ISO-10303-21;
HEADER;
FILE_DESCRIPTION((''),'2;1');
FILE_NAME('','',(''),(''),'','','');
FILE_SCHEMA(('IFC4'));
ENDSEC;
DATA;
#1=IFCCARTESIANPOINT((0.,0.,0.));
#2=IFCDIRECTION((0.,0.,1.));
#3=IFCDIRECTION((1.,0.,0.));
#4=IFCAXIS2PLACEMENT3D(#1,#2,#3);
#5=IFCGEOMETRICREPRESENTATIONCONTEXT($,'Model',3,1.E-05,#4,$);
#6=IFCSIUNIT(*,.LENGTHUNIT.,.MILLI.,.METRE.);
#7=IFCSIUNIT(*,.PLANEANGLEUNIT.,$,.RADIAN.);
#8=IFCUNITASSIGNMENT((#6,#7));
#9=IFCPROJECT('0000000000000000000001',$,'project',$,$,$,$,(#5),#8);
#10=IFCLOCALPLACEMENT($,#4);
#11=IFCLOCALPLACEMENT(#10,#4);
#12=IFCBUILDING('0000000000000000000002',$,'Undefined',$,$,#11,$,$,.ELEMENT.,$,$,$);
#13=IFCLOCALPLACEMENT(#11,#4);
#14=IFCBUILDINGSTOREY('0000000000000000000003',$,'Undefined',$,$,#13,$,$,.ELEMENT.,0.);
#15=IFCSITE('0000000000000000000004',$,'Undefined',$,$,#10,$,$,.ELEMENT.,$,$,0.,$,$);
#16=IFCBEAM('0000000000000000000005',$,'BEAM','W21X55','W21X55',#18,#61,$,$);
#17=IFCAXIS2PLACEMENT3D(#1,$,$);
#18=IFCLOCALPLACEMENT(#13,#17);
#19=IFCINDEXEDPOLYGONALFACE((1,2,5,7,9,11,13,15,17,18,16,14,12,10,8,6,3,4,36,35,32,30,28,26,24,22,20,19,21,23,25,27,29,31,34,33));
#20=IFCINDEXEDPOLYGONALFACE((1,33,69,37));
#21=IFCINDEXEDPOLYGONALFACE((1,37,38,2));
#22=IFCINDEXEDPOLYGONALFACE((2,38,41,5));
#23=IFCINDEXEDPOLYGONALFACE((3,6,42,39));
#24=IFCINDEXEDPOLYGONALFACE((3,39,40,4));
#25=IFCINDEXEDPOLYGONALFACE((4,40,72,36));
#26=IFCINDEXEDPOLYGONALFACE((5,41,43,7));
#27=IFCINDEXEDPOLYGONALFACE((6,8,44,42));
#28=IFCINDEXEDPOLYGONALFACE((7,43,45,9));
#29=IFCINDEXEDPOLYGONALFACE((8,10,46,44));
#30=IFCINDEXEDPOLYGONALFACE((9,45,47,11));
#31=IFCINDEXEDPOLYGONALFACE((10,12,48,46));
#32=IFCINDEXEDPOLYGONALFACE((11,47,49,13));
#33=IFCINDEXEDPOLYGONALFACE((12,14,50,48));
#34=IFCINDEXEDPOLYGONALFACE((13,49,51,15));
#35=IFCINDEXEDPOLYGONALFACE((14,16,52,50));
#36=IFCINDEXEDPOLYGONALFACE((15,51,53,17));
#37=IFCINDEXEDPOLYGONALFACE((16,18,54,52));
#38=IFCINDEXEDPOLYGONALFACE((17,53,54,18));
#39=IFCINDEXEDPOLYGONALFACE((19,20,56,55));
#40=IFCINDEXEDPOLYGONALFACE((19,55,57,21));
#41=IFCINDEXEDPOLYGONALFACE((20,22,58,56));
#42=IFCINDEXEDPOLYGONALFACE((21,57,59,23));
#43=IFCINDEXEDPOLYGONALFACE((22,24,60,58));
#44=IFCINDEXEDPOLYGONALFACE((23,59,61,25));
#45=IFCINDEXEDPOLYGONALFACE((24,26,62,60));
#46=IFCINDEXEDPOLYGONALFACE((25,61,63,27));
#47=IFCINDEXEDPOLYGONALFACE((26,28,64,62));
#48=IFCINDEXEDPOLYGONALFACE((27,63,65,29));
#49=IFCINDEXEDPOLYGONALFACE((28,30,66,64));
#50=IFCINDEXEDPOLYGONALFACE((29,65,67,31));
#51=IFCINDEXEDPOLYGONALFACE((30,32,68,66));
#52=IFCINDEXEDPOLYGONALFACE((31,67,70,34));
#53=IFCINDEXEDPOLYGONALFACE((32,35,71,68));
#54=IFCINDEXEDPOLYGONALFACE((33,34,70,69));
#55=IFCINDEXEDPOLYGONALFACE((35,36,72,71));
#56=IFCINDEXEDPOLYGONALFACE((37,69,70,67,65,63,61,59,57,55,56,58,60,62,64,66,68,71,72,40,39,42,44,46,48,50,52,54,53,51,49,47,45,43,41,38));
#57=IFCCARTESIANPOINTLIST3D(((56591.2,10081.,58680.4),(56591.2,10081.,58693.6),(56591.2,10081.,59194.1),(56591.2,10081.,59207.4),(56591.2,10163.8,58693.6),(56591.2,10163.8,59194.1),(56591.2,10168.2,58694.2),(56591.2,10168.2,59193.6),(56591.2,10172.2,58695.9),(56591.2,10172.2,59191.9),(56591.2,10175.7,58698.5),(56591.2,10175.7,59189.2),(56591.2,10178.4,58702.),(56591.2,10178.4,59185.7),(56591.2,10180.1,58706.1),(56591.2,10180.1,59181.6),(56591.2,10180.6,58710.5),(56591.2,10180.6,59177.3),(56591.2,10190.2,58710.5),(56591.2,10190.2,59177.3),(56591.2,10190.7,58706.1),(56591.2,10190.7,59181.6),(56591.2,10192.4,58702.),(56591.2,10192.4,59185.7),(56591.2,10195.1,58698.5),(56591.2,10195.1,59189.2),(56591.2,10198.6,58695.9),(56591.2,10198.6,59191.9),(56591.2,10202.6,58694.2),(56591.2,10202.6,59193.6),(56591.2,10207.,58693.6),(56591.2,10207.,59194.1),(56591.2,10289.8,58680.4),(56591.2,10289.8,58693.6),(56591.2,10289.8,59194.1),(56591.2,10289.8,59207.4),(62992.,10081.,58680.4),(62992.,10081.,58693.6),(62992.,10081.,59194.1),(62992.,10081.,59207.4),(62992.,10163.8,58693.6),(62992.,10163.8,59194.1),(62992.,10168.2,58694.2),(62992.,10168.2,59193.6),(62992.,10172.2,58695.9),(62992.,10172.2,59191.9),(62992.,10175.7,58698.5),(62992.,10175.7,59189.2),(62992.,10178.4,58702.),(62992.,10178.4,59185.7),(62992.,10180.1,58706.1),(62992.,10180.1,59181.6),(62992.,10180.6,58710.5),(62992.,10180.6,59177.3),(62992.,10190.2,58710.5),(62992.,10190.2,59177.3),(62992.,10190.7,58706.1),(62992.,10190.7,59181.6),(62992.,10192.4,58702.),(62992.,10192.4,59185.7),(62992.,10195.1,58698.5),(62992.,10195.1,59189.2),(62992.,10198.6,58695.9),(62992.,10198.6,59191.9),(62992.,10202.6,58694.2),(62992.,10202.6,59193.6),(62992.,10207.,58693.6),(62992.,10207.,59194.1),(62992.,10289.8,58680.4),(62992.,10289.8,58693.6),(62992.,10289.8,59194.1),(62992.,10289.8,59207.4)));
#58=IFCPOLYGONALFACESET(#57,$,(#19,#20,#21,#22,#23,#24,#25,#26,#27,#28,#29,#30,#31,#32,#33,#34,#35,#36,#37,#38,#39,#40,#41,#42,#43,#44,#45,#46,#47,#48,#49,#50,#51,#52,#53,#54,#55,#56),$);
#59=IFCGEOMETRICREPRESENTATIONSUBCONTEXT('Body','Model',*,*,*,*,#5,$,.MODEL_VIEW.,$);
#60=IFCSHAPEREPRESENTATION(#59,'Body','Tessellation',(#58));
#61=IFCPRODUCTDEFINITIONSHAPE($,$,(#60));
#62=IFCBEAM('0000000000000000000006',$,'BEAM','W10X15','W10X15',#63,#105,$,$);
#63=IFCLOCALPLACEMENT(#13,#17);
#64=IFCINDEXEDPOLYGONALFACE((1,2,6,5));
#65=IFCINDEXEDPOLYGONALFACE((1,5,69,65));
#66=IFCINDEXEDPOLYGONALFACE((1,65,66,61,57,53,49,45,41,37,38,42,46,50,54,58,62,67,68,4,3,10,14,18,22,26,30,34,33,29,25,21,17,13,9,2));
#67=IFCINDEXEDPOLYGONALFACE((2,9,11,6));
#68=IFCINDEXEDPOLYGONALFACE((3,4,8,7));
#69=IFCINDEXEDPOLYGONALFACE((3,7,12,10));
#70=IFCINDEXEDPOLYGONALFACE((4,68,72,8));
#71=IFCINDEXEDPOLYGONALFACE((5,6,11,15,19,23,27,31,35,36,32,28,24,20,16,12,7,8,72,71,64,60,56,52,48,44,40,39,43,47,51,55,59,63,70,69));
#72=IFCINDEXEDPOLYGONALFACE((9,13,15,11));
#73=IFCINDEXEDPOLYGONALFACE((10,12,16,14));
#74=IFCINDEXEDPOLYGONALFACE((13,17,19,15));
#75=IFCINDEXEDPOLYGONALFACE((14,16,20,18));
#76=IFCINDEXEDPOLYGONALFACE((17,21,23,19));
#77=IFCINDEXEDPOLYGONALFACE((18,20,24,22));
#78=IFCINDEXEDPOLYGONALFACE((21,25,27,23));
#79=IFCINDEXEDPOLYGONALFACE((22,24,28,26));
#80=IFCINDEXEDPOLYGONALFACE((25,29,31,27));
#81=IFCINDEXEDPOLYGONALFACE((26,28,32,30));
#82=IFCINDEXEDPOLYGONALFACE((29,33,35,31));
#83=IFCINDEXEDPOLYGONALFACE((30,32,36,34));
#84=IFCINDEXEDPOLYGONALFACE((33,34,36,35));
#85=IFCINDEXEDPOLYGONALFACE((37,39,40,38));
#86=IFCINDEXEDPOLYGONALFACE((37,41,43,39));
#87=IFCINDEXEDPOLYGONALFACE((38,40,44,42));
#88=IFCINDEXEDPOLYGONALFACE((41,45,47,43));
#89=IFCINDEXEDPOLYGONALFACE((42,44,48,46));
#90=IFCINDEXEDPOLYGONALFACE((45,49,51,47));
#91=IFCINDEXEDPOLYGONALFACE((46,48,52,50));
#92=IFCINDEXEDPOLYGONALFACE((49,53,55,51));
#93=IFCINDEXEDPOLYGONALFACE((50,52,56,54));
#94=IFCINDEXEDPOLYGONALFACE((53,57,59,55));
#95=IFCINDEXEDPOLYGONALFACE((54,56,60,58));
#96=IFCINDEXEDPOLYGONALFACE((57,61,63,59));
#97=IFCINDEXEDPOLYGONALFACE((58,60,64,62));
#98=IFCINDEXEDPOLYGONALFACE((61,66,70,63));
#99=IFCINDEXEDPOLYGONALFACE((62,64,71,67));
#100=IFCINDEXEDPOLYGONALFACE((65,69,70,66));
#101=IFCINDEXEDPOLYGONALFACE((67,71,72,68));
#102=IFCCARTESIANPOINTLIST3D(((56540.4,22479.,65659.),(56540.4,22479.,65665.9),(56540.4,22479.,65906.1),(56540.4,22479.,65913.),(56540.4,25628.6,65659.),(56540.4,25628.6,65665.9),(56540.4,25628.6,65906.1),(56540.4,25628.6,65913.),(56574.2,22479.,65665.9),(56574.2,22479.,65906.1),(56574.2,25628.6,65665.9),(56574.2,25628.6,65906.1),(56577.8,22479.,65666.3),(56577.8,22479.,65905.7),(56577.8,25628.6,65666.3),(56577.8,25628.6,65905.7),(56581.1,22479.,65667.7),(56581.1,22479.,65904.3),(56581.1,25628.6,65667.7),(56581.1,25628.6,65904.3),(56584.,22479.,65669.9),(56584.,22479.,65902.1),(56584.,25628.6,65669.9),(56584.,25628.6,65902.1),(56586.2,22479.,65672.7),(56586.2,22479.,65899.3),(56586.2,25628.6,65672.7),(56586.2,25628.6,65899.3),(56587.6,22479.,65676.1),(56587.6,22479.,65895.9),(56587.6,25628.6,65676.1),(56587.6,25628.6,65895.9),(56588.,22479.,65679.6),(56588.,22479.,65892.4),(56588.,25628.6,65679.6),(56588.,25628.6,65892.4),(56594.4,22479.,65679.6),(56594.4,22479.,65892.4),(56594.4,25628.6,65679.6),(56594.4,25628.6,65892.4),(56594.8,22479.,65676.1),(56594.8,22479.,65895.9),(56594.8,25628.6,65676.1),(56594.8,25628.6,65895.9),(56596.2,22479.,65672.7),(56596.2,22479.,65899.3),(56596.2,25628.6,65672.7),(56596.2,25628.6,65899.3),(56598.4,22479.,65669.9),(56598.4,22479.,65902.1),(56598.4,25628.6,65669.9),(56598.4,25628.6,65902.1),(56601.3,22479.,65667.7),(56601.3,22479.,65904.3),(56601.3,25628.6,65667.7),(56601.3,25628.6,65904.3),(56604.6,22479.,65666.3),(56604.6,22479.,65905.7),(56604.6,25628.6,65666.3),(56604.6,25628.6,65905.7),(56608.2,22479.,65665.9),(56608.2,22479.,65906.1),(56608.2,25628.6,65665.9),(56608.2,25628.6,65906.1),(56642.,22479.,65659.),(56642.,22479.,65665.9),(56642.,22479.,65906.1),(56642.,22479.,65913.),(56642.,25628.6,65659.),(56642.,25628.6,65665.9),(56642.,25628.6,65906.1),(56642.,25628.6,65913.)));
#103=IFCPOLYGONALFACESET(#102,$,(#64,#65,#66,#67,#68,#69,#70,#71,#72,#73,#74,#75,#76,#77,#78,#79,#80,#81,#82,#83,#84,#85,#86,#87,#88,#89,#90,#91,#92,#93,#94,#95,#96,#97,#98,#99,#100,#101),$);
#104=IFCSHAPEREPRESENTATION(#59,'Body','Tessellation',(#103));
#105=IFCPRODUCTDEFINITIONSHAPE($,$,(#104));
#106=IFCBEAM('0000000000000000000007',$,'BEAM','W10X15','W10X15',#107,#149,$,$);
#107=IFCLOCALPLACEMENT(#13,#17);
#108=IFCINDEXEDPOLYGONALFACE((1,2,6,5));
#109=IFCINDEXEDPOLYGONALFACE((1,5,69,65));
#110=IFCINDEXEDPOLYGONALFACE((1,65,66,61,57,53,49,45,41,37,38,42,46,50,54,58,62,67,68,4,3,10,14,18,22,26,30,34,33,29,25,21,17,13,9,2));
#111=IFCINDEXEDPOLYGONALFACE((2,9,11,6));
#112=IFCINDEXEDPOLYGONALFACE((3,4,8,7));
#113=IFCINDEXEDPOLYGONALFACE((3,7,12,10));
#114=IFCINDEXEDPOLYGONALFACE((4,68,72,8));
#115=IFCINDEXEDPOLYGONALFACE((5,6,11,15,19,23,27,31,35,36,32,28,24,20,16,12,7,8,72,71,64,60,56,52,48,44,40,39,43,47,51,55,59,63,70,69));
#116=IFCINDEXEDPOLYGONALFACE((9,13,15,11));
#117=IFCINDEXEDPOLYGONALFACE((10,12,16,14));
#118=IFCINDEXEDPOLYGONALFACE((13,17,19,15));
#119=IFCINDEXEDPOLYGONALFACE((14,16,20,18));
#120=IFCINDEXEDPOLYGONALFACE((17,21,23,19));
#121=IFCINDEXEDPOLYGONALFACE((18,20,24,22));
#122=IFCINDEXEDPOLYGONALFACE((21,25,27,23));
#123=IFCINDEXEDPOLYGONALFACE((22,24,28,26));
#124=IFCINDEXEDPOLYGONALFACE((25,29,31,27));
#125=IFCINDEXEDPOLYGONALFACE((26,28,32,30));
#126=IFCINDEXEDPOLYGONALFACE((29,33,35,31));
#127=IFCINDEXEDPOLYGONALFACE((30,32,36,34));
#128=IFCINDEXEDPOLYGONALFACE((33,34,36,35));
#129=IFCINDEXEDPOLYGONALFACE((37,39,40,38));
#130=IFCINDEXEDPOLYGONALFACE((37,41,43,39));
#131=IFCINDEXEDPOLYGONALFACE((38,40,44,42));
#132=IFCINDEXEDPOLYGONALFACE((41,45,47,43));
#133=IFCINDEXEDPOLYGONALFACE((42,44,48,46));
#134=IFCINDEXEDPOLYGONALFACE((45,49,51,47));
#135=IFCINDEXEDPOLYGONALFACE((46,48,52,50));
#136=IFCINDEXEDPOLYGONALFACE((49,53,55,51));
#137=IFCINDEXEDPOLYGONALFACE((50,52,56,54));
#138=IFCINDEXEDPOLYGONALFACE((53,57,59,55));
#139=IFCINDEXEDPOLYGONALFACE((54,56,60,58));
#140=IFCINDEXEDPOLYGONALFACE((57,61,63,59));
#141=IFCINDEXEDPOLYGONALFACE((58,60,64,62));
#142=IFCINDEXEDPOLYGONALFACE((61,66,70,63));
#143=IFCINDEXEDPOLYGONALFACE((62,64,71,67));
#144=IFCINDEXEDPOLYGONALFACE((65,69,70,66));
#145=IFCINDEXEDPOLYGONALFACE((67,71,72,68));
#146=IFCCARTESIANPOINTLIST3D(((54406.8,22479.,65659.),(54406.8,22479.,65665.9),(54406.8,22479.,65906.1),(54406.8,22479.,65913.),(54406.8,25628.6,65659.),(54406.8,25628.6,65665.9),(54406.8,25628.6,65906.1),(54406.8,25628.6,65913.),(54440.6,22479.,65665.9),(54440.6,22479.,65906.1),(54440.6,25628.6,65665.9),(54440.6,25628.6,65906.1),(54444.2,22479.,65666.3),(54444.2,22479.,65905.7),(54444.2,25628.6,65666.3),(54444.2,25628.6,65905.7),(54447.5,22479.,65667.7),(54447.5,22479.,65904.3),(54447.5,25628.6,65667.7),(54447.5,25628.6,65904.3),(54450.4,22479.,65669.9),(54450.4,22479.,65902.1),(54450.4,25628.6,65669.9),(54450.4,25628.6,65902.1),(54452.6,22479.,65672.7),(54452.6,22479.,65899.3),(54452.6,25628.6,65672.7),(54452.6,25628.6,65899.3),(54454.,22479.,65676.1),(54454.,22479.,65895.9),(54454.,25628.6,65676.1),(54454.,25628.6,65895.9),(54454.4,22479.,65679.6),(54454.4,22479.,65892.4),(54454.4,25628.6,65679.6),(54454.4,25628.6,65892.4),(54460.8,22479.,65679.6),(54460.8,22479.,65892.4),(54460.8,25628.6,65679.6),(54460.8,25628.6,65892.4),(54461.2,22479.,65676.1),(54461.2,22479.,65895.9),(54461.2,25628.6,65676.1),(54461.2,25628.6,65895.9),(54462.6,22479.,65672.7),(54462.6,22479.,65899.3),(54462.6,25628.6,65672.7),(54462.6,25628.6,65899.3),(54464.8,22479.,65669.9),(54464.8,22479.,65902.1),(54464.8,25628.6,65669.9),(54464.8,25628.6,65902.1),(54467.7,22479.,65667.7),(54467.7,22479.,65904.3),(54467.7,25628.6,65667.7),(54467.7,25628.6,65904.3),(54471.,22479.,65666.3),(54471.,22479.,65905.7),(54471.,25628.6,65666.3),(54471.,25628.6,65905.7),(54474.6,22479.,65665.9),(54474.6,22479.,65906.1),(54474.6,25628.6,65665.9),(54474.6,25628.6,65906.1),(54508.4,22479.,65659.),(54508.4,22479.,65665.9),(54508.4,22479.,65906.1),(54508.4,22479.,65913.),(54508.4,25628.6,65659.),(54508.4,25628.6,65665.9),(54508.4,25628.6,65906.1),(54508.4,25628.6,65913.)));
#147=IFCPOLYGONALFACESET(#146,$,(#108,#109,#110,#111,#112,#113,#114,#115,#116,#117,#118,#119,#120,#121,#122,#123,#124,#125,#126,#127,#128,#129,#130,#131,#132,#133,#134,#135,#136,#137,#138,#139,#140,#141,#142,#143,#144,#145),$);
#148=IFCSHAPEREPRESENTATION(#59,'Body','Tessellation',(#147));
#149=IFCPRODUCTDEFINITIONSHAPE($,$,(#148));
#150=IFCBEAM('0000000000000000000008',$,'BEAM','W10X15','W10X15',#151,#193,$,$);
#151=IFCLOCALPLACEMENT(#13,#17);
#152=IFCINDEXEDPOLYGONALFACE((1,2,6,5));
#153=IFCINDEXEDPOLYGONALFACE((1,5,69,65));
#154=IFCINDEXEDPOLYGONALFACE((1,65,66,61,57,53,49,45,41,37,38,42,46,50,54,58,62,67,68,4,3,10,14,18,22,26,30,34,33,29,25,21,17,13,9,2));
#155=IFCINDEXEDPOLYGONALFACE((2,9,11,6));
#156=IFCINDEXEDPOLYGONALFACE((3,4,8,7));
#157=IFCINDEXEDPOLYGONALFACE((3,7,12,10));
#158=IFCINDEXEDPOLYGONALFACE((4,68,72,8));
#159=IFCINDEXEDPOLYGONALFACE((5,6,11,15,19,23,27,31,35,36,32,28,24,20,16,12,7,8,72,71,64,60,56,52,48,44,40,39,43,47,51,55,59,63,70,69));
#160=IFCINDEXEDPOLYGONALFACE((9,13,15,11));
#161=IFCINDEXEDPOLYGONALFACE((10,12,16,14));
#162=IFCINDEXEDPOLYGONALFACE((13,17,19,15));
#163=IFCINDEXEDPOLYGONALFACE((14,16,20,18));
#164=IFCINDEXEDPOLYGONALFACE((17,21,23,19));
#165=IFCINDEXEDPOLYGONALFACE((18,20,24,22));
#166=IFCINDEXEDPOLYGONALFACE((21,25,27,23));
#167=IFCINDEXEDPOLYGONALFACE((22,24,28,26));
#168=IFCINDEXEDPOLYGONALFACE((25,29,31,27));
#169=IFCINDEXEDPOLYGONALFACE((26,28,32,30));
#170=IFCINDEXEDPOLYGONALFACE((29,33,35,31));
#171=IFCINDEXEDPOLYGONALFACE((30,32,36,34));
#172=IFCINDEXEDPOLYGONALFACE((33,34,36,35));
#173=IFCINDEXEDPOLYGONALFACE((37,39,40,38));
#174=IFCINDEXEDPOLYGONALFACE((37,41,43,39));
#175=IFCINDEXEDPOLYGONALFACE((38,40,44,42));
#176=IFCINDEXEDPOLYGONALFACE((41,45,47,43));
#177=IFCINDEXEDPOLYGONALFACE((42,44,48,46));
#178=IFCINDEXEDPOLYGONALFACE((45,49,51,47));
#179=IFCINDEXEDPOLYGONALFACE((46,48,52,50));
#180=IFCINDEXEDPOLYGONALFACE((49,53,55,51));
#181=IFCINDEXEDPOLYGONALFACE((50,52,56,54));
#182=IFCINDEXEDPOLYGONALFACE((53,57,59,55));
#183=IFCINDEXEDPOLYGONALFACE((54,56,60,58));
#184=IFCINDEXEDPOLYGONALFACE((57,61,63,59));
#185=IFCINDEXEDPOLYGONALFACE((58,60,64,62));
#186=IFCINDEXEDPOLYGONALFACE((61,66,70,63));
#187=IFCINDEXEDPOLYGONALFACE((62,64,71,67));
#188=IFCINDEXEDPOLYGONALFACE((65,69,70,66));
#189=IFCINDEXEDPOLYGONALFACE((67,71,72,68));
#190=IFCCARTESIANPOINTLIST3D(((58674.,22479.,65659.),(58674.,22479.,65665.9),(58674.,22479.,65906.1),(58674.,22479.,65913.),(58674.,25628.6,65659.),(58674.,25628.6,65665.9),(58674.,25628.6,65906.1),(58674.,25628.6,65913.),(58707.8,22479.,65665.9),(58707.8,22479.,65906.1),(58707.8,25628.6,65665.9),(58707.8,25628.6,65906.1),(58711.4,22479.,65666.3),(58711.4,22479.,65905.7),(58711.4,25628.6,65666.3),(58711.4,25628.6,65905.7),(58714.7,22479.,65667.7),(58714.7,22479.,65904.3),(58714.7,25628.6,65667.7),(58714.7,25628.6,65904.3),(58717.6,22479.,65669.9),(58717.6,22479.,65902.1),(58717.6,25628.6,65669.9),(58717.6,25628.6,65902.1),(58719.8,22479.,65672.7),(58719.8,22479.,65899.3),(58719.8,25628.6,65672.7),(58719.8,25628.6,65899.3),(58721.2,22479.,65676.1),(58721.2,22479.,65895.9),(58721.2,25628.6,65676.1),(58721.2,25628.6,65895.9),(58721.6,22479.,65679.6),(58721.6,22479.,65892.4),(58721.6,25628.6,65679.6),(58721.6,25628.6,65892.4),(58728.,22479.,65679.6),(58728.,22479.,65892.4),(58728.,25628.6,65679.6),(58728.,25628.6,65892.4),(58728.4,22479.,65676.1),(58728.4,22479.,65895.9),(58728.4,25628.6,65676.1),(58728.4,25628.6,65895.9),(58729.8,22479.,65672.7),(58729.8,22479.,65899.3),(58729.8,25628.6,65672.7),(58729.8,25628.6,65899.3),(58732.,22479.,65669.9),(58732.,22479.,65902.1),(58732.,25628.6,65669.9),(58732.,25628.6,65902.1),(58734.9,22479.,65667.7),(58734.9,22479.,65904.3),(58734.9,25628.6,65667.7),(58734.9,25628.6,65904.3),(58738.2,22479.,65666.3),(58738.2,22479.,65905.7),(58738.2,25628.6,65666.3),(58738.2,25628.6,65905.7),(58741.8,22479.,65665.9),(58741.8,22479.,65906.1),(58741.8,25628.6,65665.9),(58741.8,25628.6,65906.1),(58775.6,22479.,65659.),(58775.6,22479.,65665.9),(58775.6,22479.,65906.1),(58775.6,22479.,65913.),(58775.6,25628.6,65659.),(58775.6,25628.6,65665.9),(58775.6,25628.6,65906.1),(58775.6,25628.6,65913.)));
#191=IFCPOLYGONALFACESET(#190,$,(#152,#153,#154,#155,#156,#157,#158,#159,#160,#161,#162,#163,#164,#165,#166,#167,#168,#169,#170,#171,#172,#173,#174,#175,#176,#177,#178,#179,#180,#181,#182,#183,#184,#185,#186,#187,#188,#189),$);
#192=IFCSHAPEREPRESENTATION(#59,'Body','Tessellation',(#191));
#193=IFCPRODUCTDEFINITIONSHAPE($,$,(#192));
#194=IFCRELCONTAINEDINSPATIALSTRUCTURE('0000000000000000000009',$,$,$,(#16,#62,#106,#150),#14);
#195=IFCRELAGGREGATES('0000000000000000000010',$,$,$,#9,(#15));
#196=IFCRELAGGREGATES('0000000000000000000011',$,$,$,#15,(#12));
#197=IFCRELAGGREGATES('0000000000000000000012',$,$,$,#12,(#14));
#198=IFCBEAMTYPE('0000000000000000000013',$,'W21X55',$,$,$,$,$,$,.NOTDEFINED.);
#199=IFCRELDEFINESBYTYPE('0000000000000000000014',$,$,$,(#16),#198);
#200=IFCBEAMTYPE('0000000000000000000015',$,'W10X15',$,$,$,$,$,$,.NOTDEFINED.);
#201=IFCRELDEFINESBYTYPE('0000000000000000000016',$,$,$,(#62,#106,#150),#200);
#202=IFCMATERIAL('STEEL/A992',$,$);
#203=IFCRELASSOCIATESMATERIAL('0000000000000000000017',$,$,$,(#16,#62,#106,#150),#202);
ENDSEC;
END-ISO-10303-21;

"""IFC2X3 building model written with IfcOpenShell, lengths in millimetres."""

from ifc_helpers import new_model, si_unit, frame, origin_with_axes, origin_2d_with_axis, place, context, subcontext, project, spatial, i_section, extrude, material, type_object, element, save


model = new_model("IFC2X3")

# Units and contexts
model_context = context("Model", 3, precision=1e-05, world=origin_with_axes())
body_context = subcontext(model_context, "Body", "Model", "MODEL_VIEW")
ifc_project = project(units=[si_unit("LENGTHUNIT", "METRE", prefix="MILLI"), si_unit("PLANEANGLEUNIT", "RADIAN")], contexts=[model_context])

# Site, building, storey
site_placement = place(None, origin_with_axes())
site = spatial("IfcSite", under=ifc_project, at=site_placement, Name="Undefined", CompositionType="ELEMENT", RefElevation=0.0)
building_placement = place(site_placement, origin_with_axes())
building = spatial("IfcBuilding", under=site, at=building_placement, Name="Undefined", CompositionType="ELEMENT")
storey_placement = place(building_placement, origin_with_axes())
storey = spatial("IfcBuildingStorey", under=building, at=storey_placement, Name="Undefined", CompositionType="ELEMENT", Elevation=0.0)

# Shared definitions
ifc_material_1 = material(Name="STEEL/A992")

# Beams
beam_type_1 = type_object("IfcBeamType", Name="W21X55", PredefinedType="NOTDEFINED")
beam_1_placement = place(storey_placement, frame((56591.2, 10185.4, 58943.9), z_axis=(0.0, 0.0, 1.0), x_axis=(1.0, 0.0, 0.0)))
element("IfcBeam", 1, at=beam_1_placement, inside=storey, type_object=beam_type_1, material=ifc_material_1, Name="BEAM", Description="W21X55", ObjectType="W21X55", context=body_context, shape_type="SweptSolid", body=[
    extrude(i_section(OverallWidth=208.8, OverallDepth=527.0, WebThickness=9.5, FlangeThickness=13.3, FilletRadius=16.9, at=origin_2d_with_axis()), frame((6400.8, 0.0, 0.0), z_axis=(-1.0, 0.0, 0.0), x_axis=(0.0, -1.0, 0.0)), (0.0, 0.0, 1.0), 6400.8),
])
beam_type_2 = type_object("IfcBeamType", Name="W10X15", PredefinedType="NOTDEFINED")
for number, where, z_axis, x_axis, name in (
    (2, (56591.2, 22479.0, 65786.0), (0.0, 0.0, 1.0), (0.0, 1.0, 0.0), "BEAM"),
    (3, (54457.6, 22479.0, 65786.0), (0.0, 0.0, 1.0), (0.0, 1.0, 0.0), "BEAM"),
    (4, (58724.8, 22479.0, 65786.0), (0.0, 0.0, 1.0), (0.0, 1.0, 0.0), "BEAM"),
):
    element("IfcBeam", number, at=place(storey_placement, frame(where, z_axis=z_axis, x_axis=x_axis)), inside=storey, type_object=beam_type_2, material=ifc_material_1, Name=name, Description="W10X15", ObjectType="W10X15", context=body_context, shape_type="SweptSolid", body=[
        extrude(i_section(OverallWidth=101.6, OverallDepth=254.0, WebThickness=6.3, FlangeThickness=6.9, FilletRadius=13.8, at=origin_2d_with_axis()), frame((3149.6, 0.0, 0.0), z_axis=(-1.0, 0.0, 0.0), x_axis=(0.0, -1.0, 0.0)), (0.0, 0.0, 1.0), 3149.6),
    ])

save(model, "model.ifc")
